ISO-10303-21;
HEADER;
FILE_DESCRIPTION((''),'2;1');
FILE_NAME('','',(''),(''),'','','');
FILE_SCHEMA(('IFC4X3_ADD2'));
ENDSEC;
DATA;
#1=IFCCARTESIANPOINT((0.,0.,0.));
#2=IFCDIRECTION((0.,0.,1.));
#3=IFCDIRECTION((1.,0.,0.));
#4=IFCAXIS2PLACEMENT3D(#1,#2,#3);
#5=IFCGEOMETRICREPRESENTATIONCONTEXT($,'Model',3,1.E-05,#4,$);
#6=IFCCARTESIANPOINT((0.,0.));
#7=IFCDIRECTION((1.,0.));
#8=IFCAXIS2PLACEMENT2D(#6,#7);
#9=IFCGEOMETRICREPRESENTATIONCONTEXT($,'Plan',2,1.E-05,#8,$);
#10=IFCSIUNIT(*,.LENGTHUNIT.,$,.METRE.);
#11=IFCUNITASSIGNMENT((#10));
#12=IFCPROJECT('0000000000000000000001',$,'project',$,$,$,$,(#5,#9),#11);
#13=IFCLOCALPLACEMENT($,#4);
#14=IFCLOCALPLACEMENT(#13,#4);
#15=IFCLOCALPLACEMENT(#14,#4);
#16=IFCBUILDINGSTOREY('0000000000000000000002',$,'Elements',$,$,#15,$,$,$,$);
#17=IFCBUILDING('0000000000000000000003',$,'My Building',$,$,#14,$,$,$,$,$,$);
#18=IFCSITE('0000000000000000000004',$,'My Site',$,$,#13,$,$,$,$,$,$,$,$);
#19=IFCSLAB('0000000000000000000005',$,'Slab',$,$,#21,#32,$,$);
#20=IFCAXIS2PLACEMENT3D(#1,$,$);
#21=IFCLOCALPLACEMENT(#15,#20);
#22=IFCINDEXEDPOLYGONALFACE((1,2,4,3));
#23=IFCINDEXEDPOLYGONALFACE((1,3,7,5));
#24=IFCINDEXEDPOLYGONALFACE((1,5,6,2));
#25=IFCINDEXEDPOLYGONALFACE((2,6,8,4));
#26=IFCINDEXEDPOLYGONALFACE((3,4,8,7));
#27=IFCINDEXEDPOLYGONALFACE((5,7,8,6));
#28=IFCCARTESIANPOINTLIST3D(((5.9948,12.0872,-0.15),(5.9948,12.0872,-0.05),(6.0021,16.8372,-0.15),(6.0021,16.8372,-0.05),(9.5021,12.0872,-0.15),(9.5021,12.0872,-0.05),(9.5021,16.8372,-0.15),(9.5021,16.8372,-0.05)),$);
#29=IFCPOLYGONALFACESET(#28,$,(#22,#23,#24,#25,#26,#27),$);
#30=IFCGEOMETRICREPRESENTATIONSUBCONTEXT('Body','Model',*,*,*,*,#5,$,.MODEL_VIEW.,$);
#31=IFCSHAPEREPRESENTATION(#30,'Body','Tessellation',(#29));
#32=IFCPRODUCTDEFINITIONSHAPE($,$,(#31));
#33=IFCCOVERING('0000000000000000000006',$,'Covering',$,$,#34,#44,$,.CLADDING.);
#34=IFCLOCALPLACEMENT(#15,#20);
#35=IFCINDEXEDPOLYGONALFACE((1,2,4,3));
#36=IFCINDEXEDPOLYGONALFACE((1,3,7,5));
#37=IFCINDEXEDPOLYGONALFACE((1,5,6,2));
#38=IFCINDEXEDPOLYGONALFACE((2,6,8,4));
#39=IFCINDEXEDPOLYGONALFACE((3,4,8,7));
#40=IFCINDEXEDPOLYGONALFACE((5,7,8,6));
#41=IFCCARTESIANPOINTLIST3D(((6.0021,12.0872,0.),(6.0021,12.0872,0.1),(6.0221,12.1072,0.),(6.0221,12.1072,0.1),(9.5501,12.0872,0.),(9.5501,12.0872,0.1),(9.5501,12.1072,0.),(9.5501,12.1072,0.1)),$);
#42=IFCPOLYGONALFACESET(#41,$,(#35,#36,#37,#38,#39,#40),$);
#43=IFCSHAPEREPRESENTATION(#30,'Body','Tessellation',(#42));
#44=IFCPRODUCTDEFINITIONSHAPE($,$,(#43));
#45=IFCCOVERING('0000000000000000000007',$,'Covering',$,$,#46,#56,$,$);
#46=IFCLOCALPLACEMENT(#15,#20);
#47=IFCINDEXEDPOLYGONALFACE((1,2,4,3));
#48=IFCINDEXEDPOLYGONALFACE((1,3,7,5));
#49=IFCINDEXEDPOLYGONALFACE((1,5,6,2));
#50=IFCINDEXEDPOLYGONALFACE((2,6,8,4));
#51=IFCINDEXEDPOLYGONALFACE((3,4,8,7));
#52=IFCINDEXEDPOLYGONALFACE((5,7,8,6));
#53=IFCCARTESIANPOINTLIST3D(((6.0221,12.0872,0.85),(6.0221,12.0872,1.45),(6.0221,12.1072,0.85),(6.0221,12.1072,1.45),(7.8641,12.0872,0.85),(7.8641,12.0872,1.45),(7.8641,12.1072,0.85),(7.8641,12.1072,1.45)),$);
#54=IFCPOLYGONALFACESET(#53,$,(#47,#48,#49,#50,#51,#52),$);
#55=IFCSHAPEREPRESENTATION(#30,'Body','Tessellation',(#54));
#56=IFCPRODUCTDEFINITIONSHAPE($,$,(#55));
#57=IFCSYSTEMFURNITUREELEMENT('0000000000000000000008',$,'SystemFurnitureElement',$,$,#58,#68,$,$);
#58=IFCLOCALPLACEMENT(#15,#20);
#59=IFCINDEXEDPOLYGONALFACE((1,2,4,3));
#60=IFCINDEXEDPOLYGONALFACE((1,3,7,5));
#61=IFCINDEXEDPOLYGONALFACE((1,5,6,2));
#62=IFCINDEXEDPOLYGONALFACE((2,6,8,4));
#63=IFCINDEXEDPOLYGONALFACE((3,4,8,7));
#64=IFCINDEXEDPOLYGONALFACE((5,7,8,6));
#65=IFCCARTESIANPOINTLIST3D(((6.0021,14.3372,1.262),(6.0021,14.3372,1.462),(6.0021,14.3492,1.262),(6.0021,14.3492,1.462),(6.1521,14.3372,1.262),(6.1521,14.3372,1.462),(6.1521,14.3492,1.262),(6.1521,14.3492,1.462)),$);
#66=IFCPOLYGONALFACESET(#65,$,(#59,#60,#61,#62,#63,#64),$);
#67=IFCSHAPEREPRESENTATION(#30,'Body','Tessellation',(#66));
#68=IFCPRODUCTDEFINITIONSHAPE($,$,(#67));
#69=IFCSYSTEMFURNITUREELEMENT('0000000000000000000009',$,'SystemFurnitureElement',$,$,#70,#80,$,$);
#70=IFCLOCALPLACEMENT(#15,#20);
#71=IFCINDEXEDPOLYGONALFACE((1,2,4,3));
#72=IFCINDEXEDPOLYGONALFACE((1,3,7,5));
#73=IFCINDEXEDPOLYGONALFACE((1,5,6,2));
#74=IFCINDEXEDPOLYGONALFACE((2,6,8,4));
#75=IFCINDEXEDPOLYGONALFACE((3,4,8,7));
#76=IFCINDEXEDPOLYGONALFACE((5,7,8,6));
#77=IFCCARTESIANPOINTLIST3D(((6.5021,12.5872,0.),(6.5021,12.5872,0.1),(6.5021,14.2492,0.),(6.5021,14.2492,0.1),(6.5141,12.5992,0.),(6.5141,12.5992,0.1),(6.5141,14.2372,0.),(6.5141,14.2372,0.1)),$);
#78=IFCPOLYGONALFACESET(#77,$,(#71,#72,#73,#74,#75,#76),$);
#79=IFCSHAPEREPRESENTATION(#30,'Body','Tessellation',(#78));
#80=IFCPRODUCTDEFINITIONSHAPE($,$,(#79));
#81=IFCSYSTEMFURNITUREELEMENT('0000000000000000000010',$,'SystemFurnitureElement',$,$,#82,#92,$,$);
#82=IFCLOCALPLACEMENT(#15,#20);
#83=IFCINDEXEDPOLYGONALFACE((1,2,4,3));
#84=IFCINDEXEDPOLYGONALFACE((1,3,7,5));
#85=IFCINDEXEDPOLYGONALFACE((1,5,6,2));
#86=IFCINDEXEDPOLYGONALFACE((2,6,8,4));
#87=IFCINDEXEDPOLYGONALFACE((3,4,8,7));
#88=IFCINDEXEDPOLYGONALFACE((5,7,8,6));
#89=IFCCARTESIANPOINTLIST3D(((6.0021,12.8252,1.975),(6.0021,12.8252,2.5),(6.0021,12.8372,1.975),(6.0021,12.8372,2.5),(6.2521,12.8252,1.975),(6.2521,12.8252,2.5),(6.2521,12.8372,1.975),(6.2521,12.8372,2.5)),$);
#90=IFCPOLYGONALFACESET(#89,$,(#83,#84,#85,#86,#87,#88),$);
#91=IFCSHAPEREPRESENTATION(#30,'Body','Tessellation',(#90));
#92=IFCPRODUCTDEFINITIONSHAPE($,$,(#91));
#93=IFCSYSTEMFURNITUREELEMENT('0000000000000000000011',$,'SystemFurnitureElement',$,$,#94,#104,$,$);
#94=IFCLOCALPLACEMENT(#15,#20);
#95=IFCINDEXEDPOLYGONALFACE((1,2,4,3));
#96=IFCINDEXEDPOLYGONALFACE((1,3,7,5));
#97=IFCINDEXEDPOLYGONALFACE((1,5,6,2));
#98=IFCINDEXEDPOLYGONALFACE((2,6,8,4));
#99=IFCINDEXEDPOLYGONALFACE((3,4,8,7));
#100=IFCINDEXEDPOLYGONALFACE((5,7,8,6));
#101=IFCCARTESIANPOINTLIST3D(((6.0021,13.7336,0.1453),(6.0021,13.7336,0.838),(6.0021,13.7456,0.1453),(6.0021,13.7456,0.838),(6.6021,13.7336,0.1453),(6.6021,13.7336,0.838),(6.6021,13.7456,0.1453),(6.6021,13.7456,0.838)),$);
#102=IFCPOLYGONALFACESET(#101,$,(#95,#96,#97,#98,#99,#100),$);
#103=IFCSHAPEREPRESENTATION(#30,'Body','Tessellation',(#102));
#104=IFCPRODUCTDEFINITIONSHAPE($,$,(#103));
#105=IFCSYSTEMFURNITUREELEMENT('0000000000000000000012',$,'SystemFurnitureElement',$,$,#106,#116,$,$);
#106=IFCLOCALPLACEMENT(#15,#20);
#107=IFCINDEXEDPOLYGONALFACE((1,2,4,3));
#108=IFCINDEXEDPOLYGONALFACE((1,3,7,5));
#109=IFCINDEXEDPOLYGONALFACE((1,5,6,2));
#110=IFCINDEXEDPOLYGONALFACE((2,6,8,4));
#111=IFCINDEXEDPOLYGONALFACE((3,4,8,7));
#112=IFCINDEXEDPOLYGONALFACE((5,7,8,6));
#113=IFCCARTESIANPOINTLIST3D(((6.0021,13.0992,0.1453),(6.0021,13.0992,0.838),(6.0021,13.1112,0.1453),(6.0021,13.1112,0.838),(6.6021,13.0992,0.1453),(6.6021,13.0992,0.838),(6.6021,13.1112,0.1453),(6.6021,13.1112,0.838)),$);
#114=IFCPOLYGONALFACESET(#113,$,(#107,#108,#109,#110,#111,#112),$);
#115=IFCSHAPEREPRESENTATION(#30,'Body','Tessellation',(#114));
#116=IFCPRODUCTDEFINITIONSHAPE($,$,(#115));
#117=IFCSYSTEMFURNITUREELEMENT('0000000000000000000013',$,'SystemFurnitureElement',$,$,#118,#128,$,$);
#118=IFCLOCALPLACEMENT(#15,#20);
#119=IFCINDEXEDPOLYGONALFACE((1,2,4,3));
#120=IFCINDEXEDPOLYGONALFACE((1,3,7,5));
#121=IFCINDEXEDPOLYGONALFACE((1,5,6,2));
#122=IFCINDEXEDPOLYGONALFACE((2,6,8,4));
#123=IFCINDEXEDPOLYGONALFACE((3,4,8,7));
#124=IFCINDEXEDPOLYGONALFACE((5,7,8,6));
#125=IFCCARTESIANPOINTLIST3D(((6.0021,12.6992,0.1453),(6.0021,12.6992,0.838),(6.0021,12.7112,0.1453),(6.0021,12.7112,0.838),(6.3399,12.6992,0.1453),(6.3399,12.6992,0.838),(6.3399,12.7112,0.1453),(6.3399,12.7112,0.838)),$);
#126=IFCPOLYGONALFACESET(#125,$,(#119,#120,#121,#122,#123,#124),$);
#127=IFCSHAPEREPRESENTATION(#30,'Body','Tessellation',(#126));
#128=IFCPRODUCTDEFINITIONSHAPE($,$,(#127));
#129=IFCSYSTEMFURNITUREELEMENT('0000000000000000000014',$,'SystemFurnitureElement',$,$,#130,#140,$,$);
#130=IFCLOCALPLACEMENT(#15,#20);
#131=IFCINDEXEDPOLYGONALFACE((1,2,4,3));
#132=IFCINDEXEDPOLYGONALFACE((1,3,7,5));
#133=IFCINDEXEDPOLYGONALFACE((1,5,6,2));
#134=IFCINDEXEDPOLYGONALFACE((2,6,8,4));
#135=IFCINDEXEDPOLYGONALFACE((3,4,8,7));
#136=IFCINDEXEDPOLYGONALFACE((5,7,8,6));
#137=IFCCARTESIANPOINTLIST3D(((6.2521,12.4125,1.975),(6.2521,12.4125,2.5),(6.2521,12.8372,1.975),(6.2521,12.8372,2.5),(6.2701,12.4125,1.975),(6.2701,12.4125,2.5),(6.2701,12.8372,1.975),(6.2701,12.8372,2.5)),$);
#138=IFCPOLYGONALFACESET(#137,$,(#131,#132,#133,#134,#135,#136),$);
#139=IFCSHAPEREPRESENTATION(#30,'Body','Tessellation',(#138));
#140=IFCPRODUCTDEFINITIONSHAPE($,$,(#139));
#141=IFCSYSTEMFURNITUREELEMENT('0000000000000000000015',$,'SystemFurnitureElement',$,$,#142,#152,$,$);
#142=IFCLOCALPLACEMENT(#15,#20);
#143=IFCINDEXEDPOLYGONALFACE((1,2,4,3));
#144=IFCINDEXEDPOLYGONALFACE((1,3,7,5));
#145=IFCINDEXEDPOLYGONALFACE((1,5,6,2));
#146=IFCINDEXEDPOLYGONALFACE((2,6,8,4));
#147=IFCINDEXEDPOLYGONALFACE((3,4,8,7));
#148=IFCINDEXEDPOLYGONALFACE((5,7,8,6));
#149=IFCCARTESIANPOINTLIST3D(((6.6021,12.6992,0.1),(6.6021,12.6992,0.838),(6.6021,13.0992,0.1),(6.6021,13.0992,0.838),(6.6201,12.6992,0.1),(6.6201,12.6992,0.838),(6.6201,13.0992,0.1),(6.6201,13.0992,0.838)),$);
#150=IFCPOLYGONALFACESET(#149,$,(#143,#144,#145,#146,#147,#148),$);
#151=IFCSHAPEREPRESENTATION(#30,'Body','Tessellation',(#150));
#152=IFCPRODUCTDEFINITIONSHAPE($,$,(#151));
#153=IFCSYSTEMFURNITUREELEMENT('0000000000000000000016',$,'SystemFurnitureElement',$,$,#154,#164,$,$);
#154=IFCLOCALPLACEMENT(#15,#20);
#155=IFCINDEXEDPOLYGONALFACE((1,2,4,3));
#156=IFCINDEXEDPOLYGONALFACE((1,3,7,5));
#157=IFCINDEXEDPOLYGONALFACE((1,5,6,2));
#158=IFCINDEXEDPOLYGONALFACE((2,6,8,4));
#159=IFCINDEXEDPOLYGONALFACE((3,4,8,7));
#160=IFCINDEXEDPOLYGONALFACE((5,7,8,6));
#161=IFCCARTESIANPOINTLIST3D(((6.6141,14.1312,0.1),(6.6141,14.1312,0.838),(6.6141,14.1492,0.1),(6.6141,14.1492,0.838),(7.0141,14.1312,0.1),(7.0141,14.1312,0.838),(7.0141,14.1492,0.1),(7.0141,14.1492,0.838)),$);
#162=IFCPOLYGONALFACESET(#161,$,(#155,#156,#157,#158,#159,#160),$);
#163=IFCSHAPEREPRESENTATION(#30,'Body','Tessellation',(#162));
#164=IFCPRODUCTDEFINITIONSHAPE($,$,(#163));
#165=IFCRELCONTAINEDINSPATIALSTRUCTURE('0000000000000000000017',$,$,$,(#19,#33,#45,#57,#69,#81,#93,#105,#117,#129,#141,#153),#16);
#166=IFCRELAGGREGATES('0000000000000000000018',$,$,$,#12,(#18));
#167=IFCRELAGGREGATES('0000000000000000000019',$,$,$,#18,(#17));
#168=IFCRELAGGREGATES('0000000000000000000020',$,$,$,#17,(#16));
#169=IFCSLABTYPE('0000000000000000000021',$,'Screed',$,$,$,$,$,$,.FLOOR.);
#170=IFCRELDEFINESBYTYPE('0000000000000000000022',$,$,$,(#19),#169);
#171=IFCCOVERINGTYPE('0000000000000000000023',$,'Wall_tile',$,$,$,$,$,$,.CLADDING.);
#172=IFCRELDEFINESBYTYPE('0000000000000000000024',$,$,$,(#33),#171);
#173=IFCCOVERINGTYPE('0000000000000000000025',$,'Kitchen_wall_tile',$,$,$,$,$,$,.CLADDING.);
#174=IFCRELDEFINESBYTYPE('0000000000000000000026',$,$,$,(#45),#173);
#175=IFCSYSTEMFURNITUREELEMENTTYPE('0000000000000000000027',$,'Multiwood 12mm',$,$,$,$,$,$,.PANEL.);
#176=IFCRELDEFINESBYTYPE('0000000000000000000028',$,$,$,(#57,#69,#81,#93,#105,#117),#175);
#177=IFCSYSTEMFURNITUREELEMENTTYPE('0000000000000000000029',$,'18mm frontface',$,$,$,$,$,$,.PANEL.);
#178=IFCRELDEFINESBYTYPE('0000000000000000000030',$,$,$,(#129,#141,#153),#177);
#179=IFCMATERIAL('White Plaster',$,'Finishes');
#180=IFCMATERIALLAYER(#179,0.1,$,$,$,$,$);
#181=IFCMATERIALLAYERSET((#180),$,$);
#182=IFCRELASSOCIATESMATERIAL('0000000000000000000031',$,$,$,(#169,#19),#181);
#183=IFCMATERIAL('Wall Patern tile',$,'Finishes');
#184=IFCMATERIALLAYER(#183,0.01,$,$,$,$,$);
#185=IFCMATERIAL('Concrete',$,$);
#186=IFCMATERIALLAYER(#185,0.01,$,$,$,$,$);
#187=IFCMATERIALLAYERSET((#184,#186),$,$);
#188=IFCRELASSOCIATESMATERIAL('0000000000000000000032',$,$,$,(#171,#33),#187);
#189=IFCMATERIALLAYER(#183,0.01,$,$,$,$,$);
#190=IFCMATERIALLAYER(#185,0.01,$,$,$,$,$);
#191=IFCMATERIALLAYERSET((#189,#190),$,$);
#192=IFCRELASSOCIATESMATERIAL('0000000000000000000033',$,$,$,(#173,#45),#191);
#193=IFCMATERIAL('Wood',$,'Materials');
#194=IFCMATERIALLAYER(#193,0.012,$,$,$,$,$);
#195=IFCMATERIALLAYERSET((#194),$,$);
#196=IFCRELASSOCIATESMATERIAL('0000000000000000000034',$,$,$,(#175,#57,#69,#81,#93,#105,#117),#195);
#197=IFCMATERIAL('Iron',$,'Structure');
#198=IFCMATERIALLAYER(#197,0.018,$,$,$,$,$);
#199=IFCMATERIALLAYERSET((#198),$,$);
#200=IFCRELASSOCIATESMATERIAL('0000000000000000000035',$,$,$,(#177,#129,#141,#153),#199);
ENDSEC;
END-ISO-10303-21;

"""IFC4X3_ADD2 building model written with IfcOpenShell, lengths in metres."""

from ifc_helpers import new_model, si_unit, frame, origin_with_axes, origin_2d_with_axis, place, context, subcontext, project, spatial, line, indexed_curve, outline, extrude, material, layer, layer_set, layer_usage, type_object, element, save


model = new_model("IFC4X3_ADD2")

# Units and contexts
model_context = context("Model", 3, precision=1e-05, world=origin_with_axes())
plan_context = context("Plan", 2, precision=1e-05, world=origin_2d_with_axis())
body_context = subcontext(model_context, "Body", "Model", "MODEL_VIEW")
ifc_project = project(units=[si_unit("LENGTHUNIT", "METRE")], contexts=[model_context, plan_context])

# Site, building, storey
site_placement = place(None, origin_with_axes())
site = spatial("IfcSite", under=ifc_project, at=site_placement, Name="My Site")
building_placement = place(site_placement, origin_with_axes())
building = spatial("IfcBuilding", under=site, at=building_placement, Name="My Building")
storey_placement = place(building_placement, origin_with_axes())
storey = spatial("IfcBuildingStorey", under=building, at=storey_placement, Name="Elements")

# Slab
ifc_material_1 = material(Name="White Plaster", Category="Finishes")
ifc_layer_1 = layer(ifc_material_1, 0.1)
ifc_layer_set_1 = layer_set([ifc_layer_1])
ifc_layer_usage_1 = layer_usage(ifc_layer_set_1, "AXIS3", "POSITIVE", -0.1)
slab_type = type_object("IfcSlabType", Name="Screed", PredefinedType="FLOOR", material=ifc_layer_set_1)
slab_placement = place(storey_placement, frame((5.9948, 12.0872, -0.05), z_axis=(0.0, 0.0, 1.0), x_axis=(1.0, 0.0, 0.0)))
element("IfcSlab", 1, at=slab_placement, inside=storey, type_object=slab_type, material=ifc_layer_usage_1, Name="Slab", context=body_context, shape_type="SweptSolid", body=[
    extrude(outline(indexed_curve([(0.0, 0.0), (3.5073, 0.0), (3.5073, 4.75), (0.0073, 4.75), (0.0, 0.0)])), frame((0.0, 0.0, -0.1), z_axis=(0.0, 0.0, 1.0), x_axis=(1.0, 0.0, 0.0)), (0.0, 0.0, 1.0), 0.1),
])

# Coverings
ifc_material_2 = material(Name="Wall Patern tile", Category="Finishes")
ifc_layer_2 = layer(ifc_material_2, 0.01)
ifc_material_3 = material(Name="Concrete")
ifc_layer_3 = layer(ifc_material_3, 0.01)
ifc_layer_set_2 = layer_set([ifc_layer_2, ifc_layer_3])
ifc_layer_usage_2 = layer_usage(ifc_layer_set_2, "AXIS2", "NEGATIVE", 0.0)
covering_type_1 = type_object("IfcCoveringType", Name="Wall_tile", PredefinedType="CLADDING", material=ifc_layer_set_2)
covering_1_placement = place(storey_placement, frame((6.0221, 12.1072, 0.0), z_axis=(0.0, 0.0, 1.0), x_axis=(1.0, 0.0, 0.0)))
element("IfcCovering", 2, at=covering_1_placement, inside=storey, type_object=covering_type_1, material=ifc_layer_usage_2, Name="Covering", PredefinedType="CLADDING", context=body_context, shape_type="SweptSolid", body=[
    extrude(outline(indexed_curve([(-0.02, -0.02), (0.0, 0.0), (3.528, 0.0), (3.528, -0.02)], segments=[line(1, 2, 3, 4, 1)])), origin_with_axes(), (0.0, 0.0, 1.0), 0.1),
])
ifc_layer_4 = layer(ifc_material_2, 0.01)
ifc_layer_5 = layer(ifc_material_3, 0.01)
ifc_layer_set_3 = layer_set([ifc_layer_4, ifc_layer_5])
ifc_layer_usage_3 = layer_usage(ifc_layer_set_3, "AXIS2", "NEGATIVE", 0.0)
covering_type_2 = type_object("IfcCoveringType", Name="Kitchen_wall_tile", PredefinedType="CLADDING", material=ifc_layer_set_3)
covering_2_placement = place(storey_placement, frame((6.0221, 12.1072, 0.85), z_axis=(0.0, 0.0, 1.0), x_axis=(1.0, 0.0, 0.0)))
element("IfcCovering", 3, at=covering_2_placement, inside=storey, type_object=covering_type_2, material=ifc_layer_usage_3, Name="Covering", context=body_context, shape_type="SweptSolid", body=[
    extrude(outline(indexed_curve([(0.0, -0.02), (0.0, 0.0), (1.842, 0.0), (1.842, -0.02)], segments=[line(1, 2, 3, 4, 1)])), origin_with_axes(), (0.0, 0.0, 1.0), 0.6),
])

# System furniture elements
ifc_material_4 = material(Name="Wood", Category="Materials")
ifc_layer_6 = layer(ifc_material_4, 0.012)
ifc_layer_set_4 = layer_set([ifc_layer_6])
ifc_layer_usage_4 = layer_usage(ifc_layer_set_4, "AXIS2", "POSITIVE", 0.0)
system_furniture_element_type_1 = type_object("IfcSystemFurnitureElementType", Name="Multiwood 12mm", PredefinedType="PANEL", material=ifc_layer_set_4)
system_furniture_element_1_placement = place(storey_placement, frame((6.1521, 14.3492, 1.262), z_axis=(0.0, 0.0, 1.0), x_axis=(-1.0, 0.000001, 0.0)))
element("IfcSystemFurnitureElement", 4, at=system_furniture_element_1_placement, inside=storey, type_object=system_furniture_element_type_1, material=ifc_layer_usage_4, Name="SystemFurnitureElement", context=body_context, shape_type="SweptSolid", body=[
    extrude(outline(indexed_curve([(0.0, 0.0), (0.0, 0.012), (0.15, 0.012), (0.15, 0.0)], segments=[line(1, 2, 3, 4, 1)])), origin_with_axes(), (0.0, 0.0, 1.0), 0.2),
])
ifc_layer_usage_5 = layer_usage(ifc_layer_set_4, "AXIS2", "POSITIVE", 0.0)
system_furniture_element_2_placement = place(storey_placement, frame((6.5021, 14.2492, 0.0), z_axis=(0.0, 0.0, 1.0), x_axis=(0.0, -1.0, 0.0)))
element("IfcSystemFurnitureElement", 5, at=system_furniture_element_2_placement, inside=storey, type_object=system_furniture_element_type_1, material=ifc_layer_usage_5, Name="SystemFurnitureElement", context=body_context, shape_type="SweptSolid", body=[
    extrude(outline(indexed_curve([(0.0, 0.0), (0.012, 0.012), (1.6501, 0.012), (1.6621, 0.0)], segments=[line(1, 2, 3, 4, 1)])), origin_with_axes(), (0.0, 0.0, 1.0), 0.1),
])
ifc_layer_usage_6 = layer_usage(ifc_layer_set_4, "AXIS2", "NEGATIVE", 0.0)
system_furniture_element_3_placement = place(storey_placement, frame((6.2521, 12.8252, 1.975), z_axis=(0.0, 0.0, 1.0), x_axis=(-1.0, 0.0, 0.0)))
element("IfcSystemFurnitureElement", 6, at=system_furniture_element_3_placement, inside=storey, type_object=system_furniture_element_type_1, material=ifc_layer_usage_6, Name="SystemFurnitureElement", context=body_context, shape_type="SweptSolid", body=[
    extrude(outline(indexed_curve([(0.0, -0.012), (0.0, 0.0), (0.25, 0.0), (0.25, -0.012)], segments=[line(1, 2, 3, 4, 1)])), origin_with_axes(), (0.0, 0.0, 1.0), 0.525),
])
ifc_layer_usage_7 = layer_usage(ifc_layer_set_4, "AXIS2", "POSITIVE", 0.0)
system_furniture_element_4_placement = place(storey_placement, frame((6.0021, 13.7336, 0.1453), z_axis=(0.0, 0.0, 1.0), x_axis=(1.0, 0.0, 0.0)))
element("IfcSystemFurnitureElement", 7, at=system_furniture_element_4_placement, inside=storey, type_object=system_furniture_element_type_1, material=ifc_layer_usage_7, Name="SystemFurnitureElement", context=body_context, shape_type="SweptSolid", body=[
    extrude(outline(indexed_curve([(0.0, 0.0), (0.0, 0.012), (0.6, 0.012), (0.6, 0.0)], segments=[line(1, 2, 3, 4, 1)])), origin_with_axes(), (0.0, 0.0, 1.0), 0.6927),
])
ifc_layer_usage_8 = layer_usage(ifc_layer_set_4, "AXIS2", "POSITIVE", 0.0)
system_furniture_element_5_placement = place(storey_placement, frame((6.0021, 13.0992, 0.1453), z_axis=(0.0, 0.0, 1.0), x_axis=(1.0, 0.0, 0.0)))
element("IfcSystemFurnitureElement", 8, at=system_furniture_element_5_placement, inside=storey, type_object=system_furniture_element_type_1, material=ifc_layer_usage_8, Name="SystemFurnitureElement", context=body_context, shape_type="SweptSolid", body=[
    extrude(outline(indexed_curve([(0.0, 0.0), (0.0, 0.012), (0.6, 0.012), (0.6, 0.0)], segments=[line(1, 2, 3, 4, 1)])), origin_with_axes(), (0.0, 0.0, 1.0), 0.6927),
])
ifc_layer_usage_9 = layer_usage(ifc_layer_set_4, "AXIS2", "POSITIVE", 0.0)
system_furniture_element_6_placement = place(storey_placement, frame((6.0021, 12.6992, 0.1453), z_axis=(0.0, 0.0, 1.0), x_axis=(1.0, 0.0, 0.0)))
element("IfcSystemFurnitureElement", 9, at=system_furniture_element_6_placement, inside=storey, type_object=system_furniture_element_type_1, material=ifc_layer_usage_9, Name="SystemFurnitureElement", context=body_context, shape_type="SweptSolid", body=[
    extrude(outline(indexed_curve([(0.0, 0.0), (0.0, 0.012), (0.3378, 0.012), (0.3378, 0.0)], segments=[line(1, 2, 3, 4, 1)])), origin_with_axes(), (0.0, 0.0, 1.0), 0.6927),
])
ifc_material_5 = material(Name="Iron", Category="Structure")
ifc_layer_7 = layer(ifc_material_5, 0.018)
ifc_layer_set_5 = layer_set([ifc_layer_7])
ifc_layer_usage_10 = layer_usage(ifc_layer_set_5, "AXIS2", "POSITIVE", 0.0)
system_furniture_element_type_2 = type_object("IfcSystemFurnitureElementType", Name="18mm frontface", PredefinedType="PANEL", material=ifc_layer_set_5)
system_furniture_element_7_placement = place(storey_placement, frame((6.2521, 12.8372, 1.975), z_axis=(0.0, 0.0, 1.0), x_axis=(0.0, -1.0, 0.0)))
element("IfcSystemFurnitureElement", 10, at=system_furniture_element_7_placement, inside=storey, type_object=system_furniture_element_type_2, material=ifc_layer_usage_10, Name="SystemFurnitureElement", context=body_context, shape_type="SweptSolid", body=[
    extrude(outline(indexed_curve([(0.0, 0.0), (0.0, 0.018), (0.4246, 0.018), (0.4246, 0.0)], segments=[line(1, 2, 3, 4, 1)])), origin_with_axes(), (0.0, 0.0, 1.0), 0.525),
])
ifc_layer_usage_11 = layer_usage(ifc_layer_set_5, "AXIS2", "POSITIVE", 0.0)
system_furniture_element_8_placement = place(storey_placement, frame((6.6021, 13.0992, 0.1), z_axis=(0.0, 0.0, 1.0), x_axis=(0.0, -1.0, 0.0)))
element("IfcSystemFurnitureElement", 11, at=system_furniture_element_8_placement, inside=storey, type_object=system_furniture_element_type_2, material=ifc_layer_usage_11, Name="SystemFurnitureElement", context=body_context, shape_type="SweptSolid", body=[
    extrude(outline(indexed_curve([(0.0, 0.0), (0.0, 0.018), (0.4, 0.018), (0.4, 0.0)], segments=[line(1, 2, 3, 4, 1)])), origin_with_axes(), (0.0, 0.0, 1.0), 0.738),
])
ifc_layer_usage_12 = layer_usage(ifc_layer_set_5, "AXIS2", "POSITIVE", 0.0)
system_furniture_element_9_placement = place(storey_placement, frame((7.0141, 14.1492, 0.1), z_axis=(0.0, 0.0, 1.0), x_axis=(-1.0, 0.0, 0.0)))
element("IfcSystemFurnitureElement", 12, at=system_furniture_element_9_placement, inside=storey, type_object=system_furniture_element_type_2, material=ifc_layer_usage_12, Name="SystemFurnitureElement", context=body_context, shape_type="SweptSolid", body=[
    extrude(outline(indexed_curve([(0.0, 0.0), (0.0, 0.018), (0.4, 0.018), (0.4, 0.0)], segments=[line(1, 2, 3, 4, 1)])), origin_with_axes(), (0.0, 0.0, 1.0), 0.738),
])

save(model, "model.ifc")
